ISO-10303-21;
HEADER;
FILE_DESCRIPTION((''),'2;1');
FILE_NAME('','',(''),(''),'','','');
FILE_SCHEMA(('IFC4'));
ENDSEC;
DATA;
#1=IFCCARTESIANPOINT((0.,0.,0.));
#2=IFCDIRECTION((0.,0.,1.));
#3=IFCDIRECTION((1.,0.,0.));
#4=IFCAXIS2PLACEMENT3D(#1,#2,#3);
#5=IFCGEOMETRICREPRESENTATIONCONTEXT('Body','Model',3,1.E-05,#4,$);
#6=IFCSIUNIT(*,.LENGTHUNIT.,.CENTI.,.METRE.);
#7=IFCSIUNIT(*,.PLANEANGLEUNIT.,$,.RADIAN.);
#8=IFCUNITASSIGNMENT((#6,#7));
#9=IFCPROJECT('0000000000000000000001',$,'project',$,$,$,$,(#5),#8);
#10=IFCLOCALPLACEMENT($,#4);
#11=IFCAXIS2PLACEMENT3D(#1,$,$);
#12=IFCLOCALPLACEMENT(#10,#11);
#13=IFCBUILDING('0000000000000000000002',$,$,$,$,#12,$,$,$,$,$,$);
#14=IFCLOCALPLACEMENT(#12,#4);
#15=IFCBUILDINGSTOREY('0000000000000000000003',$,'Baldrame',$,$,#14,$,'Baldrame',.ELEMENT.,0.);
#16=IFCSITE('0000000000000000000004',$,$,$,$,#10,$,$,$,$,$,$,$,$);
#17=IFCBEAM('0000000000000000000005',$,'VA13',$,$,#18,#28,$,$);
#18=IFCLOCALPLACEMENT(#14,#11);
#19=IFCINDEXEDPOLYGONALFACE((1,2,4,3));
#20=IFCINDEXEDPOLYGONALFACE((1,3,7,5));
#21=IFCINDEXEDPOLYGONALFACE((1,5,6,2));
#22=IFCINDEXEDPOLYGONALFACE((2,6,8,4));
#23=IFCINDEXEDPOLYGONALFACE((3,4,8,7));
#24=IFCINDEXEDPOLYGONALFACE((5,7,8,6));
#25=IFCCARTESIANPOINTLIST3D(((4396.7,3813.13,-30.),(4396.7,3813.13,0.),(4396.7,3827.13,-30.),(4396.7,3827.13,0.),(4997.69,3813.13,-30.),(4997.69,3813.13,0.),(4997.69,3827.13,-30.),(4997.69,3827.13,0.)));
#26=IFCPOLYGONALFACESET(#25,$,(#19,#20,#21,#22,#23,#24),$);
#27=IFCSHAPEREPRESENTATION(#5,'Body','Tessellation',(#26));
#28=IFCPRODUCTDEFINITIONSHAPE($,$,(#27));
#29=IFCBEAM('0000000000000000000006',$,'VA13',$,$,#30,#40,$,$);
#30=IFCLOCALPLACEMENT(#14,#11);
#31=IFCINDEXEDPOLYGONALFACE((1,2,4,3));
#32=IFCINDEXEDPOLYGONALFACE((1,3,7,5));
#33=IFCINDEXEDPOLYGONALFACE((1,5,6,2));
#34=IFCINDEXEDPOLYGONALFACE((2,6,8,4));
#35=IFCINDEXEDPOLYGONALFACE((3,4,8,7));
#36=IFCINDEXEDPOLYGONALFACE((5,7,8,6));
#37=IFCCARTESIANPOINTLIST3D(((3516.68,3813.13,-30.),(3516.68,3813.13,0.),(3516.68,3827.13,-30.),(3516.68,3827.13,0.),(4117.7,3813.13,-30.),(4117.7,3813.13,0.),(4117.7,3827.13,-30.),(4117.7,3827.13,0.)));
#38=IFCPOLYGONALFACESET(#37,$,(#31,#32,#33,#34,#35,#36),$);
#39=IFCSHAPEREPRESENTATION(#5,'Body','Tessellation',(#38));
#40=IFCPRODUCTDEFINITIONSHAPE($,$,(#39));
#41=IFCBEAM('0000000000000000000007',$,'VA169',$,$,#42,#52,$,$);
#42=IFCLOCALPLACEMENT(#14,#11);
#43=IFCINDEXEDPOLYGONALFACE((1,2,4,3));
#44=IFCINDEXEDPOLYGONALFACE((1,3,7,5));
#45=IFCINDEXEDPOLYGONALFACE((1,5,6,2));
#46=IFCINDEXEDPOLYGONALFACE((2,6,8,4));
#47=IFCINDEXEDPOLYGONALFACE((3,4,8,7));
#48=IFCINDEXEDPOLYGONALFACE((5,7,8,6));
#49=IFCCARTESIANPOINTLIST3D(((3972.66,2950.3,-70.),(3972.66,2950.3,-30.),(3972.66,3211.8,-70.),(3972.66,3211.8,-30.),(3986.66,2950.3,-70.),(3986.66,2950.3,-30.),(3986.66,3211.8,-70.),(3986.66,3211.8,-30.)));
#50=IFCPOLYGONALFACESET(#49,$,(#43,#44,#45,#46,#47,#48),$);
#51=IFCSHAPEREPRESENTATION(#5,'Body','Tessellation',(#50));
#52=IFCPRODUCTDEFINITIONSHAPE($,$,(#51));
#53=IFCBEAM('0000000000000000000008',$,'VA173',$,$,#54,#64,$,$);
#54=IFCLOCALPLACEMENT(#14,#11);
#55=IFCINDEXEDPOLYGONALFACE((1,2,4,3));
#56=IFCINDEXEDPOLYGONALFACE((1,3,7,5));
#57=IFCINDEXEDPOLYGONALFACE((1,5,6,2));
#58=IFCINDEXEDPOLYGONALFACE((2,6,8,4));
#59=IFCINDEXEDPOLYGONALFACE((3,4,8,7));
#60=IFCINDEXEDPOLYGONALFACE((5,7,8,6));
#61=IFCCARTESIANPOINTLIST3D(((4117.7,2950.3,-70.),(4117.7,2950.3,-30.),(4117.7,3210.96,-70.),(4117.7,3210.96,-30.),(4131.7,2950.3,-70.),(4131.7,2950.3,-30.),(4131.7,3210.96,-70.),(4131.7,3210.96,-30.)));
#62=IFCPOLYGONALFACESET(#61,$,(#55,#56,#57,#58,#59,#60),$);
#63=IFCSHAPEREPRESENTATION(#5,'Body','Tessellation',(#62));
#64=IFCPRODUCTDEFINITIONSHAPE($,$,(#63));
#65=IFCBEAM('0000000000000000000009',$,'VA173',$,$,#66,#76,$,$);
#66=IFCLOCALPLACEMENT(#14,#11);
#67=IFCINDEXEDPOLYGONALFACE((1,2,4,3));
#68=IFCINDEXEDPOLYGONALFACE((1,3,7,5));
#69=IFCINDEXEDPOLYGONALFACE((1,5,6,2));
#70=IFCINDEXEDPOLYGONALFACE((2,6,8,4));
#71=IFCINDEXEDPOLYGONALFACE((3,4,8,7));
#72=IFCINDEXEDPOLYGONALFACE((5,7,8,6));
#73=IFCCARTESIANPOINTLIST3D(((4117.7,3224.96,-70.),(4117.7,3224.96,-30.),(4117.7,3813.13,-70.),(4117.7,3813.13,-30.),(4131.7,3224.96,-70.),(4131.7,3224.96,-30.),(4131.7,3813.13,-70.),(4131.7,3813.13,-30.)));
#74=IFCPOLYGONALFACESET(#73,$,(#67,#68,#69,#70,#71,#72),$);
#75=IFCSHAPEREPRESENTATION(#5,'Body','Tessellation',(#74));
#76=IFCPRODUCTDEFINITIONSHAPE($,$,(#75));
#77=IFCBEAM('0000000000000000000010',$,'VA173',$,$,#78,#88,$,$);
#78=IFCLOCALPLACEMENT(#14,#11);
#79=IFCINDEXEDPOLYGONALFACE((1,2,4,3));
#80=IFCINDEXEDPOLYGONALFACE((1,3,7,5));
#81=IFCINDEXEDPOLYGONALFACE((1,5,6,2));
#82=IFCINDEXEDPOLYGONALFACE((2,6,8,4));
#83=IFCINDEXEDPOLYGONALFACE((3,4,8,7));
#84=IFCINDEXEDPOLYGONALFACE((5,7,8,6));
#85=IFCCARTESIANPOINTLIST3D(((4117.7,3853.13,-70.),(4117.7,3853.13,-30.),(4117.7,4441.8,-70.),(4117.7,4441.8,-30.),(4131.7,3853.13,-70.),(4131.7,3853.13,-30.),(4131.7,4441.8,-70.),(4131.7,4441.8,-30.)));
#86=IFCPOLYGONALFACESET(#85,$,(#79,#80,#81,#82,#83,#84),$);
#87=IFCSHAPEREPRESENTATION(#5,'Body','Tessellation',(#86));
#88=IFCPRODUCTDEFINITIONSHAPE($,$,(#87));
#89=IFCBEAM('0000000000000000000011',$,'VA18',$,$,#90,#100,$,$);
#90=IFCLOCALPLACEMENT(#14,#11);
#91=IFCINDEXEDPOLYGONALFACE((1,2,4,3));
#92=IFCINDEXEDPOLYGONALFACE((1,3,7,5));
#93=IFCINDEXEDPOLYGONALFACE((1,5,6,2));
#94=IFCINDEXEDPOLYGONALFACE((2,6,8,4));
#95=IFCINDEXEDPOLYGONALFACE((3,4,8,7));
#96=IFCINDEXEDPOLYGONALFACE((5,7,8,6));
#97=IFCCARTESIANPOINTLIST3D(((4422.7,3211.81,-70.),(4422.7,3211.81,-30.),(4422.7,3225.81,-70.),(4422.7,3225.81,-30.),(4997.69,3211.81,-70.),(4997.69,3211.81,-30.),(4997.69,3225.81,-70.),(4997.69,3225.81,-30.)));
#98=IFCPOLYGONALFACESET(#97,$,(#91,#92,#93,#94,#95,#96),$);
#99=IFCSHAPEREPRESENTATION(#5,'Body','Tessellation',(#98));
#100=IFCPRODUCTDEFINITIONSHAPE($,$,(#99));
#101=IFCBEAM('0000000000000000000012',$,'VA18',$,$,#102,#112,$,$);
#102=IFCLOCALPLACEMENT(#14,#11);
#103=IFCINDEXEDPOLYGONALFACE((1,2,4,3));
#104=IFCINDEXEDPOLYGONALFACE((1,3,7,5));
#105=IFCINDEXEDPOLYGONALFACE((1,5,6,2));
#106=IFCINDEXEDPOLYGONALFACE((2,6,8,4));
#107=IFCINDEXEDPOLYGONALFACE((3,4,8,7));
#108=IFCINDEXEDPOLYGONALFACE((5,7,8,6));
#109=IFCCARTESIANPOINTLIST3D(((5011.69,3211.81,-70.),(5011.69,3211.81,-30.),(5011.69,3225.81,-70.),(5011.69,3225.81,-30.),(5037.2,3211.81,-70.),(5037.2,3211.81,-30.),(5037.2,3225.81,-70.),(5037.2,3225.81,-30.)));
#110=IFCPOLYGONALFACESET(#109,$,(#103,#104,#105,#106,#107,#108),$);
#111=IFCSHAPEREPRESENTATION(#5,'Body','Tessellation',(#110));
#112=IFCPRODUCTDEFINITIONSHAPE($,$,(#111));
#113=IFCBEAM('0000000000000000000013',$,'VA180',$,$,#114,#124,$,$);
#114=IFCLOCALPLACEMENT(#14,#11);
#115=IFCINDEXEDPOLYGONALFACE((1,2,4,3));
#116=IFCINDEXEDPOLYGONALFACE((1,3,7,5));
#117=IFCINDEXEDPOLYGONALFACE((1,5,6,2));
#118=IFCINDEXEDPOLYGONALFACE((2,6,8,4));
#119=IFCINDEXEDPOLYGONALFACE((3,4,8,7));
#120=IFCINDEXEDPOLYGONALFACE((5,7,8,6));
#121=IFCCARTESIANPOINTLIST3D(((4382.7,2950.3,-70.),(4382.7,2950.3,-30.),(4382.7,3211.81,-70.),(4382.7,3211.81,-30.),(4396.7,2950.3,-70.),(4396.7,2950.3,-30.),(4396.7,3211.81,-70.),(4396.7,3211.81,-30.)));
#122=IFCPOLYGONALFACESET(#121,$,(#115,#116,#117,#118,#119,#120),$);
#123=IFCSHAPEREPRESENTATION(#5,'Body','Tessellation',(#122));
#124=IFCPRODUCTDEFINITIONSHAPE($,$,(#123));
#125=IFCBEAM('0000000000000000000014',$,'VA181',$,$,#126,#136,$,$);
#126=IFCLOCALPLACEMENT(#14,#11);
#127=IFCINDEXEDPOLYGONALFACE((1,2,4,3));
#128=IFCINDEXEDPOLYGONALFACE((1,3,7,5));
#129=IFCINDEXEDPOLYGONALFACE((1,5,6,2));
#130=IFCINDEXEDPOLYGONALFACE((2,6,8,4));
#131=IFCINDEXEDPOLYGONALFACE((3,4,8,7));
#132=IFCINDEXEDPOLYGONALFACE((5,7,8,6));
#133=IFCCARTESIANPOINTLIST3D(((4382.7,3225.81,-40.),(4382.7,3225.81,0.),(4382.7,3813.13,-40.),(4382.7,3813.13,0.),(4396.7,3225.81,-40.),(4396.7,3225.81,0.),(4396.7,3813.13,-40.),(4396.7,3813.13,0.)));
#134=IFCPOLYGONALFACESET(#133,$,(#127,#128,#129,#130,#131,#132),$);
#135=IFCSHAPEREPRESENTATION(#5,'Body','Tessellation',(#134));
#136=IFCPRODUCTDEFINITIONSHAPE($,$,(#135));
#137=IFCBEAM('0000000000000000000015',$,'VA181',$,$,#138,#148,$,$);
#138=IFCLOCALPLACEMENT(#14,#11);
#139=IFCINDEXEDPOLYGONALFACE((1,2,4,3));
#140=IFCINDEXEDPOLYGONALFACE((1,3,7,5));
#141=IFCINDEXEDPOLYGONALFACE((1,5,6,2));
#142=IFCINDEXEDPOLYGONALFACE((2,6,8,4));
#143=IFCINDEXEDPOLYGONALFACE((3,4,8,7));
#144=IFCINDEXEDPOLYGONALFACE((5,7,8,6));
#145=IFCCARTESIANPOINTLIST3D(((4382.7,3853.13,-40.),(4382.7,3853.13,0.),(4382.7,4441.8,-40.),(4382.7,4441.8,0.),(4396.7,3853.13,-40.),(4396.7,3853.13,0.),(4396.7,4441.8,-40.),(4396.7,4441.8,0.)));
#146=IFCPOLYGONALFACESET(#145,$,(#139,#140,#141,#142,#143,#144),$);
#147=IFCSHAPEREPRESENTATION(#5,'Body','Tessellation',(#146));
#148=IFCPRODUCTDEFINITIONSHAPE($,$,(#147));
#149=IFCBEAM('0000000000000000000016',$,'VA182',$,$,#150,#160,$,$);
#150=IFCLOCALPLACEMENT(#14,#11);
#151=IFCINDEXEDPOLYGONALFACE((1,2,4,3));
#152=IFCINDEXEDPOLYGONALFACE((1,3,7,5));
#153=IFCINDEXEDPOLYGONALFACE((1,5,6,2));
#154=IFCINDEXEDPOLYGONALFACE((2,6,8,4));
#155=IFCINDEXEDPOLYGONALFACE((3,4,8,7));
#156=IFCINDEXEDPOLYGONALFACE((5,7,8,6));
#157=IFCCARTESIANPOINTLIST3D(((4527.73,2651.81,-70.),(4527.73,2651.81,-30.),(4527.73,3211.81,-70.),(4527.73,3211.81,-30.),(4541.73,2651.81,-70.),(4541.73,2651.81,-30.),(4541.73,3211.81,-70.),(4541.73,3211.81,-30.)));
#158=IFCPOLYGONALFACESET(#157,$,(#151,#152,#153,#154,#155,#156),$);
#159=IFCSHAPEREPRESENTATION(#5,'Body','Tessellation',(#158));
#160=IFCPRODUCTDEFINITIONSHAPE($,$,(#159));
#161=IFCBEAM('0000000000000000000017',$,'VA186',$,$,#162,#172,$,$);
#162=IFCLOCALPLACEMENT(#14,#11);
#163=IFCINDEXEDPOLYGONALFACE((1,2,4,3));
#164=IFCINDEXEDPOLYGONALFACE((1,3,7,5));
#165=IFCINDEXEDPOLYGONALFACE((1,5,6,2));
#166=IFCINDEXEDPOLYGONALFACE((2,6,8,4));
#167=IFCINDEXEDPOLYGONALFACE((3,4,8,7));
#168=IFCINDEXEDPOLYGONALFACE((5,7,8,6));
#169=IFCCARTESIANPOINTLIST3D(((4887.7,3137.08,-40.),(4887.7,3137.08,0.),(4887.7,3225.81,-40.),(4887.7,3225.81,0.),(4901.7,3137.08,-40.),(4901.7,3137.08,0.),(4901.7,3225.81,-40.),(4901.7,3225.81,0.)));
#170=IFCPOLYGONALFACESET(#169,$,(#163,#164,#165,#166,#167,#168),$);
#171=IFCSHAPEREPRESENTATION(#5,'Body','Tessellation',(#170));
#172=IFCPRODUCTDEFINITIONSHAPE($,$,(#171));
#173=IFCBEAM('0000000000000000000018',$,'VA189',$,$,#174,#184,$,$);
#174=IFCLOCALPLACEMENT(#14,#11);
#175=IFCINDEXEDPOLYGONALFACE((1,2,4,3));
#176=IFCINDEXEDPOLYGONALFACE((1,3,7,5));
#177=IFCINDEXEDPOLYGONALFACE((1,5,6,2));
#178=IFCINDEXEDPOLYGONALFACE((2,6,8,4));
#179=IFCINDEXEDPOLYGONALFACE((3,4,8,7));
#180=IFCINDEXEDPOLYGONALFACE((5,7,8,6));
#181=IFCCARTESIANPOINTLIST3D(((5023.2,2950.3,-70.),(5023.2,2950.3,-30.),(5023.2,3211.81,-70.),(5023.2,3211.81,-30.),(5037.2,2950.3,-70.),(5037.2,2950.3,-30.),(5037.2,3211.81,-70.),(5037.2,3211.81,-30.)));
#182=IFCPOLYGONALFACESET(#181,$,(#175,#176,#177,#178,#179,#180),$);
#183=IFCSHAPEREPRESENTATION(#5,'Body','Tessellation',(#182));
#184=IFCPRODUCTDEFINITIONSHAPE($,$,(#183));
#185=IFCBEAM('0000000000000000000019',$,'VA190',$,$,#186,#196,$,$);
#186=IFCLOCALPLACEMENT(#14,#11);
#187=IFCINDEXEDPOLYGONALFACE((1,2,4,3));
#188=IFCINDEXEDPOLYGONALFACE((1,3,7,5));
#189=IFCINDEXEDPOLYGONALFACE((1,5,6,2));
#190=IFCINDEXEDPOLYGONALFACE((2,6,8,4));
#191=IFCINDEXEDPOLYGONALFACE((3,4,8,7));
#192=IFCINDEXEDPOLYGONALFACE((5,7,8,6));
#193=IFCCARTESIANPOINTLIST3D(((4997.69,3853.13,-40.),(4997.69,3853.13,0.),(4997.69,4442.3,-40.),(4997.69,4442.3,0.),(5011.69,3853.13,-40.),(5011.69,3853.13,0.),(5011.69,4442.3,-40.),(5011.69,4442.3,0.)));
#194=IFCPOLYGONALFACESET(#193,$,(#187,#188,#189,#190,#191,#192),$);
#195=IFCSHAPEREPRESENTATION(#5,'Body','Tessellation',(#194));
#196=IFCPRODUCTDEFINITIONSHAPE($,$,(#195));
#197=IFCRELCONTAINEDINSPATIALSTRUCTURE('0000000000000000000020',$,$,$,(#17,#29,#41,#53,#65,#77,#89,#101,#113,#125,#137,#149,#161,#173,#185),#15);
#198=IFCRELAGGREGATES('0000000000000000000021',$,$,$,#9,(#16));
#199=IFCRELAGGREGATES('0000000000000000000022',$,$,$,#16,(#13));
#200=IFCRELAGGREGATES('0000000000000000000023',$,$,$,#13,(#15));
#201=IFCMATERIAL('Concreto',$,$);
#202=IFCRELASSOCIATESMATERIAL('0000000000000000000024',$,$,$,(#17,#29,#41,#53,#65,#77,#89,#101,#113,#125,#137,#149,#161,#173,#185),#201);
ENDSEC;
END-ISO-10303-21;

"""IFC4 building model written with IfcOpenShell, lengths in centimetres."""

from ifc_helpers import new_model, si_unit, frame, origin, origin_with_axes, origin_2d_with_axis, place, context, project, spatial, rectangle, extrude, material, element, save


model = new_model("IFC4")

# Units and contexts
model_context = context("Model", 3, precision=1e-05, world=origin_with_axes(), identifier="Body")
ifc_project = project(units=[si_unit("LENGTHUNIT", "METRE", prefix="CENTI"), si_unit("PLANEANGLEUNIT", "RADIAN")], contexts=[model_context])

# Site, building, storey
site_placement = place(None, origin_with_axes())
site = spatial("IfcSite", under=ifc_project, at=site_placement)
building_placement = place(site_placement, origin())
building = spatial("IfcBuilding", under=site, at=building_placement)
storey_placement = place(building_placement, origin_with_axes())
storey = spatial("IfcBuildingStorey", under=building, at=storey_placement, Name="Baldrame", LongName="Baldrame", CompositionType="ELEMENT", Elevation=0.0)

# Shared definitions
ifc_material = material(Name="Concreto")

# Beams
beam_1_placement = place(storey_placement, frame((4697.19, 3820.13, 0.0), z_axis=(0.0, 0.0, 1.0), x_axis=(1.0, 0.0, 0.0)))
element("IfcBeam", 1, at=beam_1_placement, inside=storey, material=ifc_material, Name="VA13", context=model_context, shape_type="SolidModel", body=[
    extrude(rectangle(XDim=14.0, YDim=30.0, at=origin_2d_with_axis()), frame((-300.5, 0.0, -15.0), z_axis=(1.0, 0.0, 0.0), x_axis=(0.0, 1.0, 0.0)), (0.0, 0.0, 1.0), 600.99),
])
beam_2_placement = place(storey_placement, frame((3817.19, 3820.13, 0.0), z_axis=(0.0, 0.0, 1.0), x_axis=(1.0, 0.0, 0.0)))
element("IfcBeam", 2, at=beam_2_placement, inside=storey, material=ifc_material, Name="VA13", context=model_context, shape_type="SolidModel", body=[
    extrude(rectangle(XDim=14.0, YDim=30.0, at=origin_2d_with_axis()), frame((-300.51, 0.0, -15.0), z_axis=(1.0, 0.0, 0.0), x_axis=(0.0, 1.0, 0.0)), (0.0, 0.0, 1.0), 601.02),
])
beam_3_placement = place(storey_placement, frame((3979.66, 3081.05, -30.0), z_axis=(0.0, 0.0, 1.0), x_axis=(1.0, 0.0, 0.0)))
element("IfcBeam", 3, at=beam_3_placement, inside=storey, material=ifc_material, Name="VA169", context=model_context, shape_type="SolidModel", body=[
    extrude(rectangle(XDim=14.0, YDim=40.0, at=origin_2d_with_axis()), frame((0.0, -130.75, -20.0), z_axis=(0.0, 1.0, 0.0), x_axis=(1.0, 0.0, 0.0)), (0.0, 0.0, 1.0), 261.5),
])
beam_4_placement = place(storey_placement, frame((4124.7, 3080.63, -30.0), z_axis=(0.0, 0.0, 1.0), x_axis=(1.0, 0.0, 0.0)))
element("IfcBeam", 4, at=beam_4_placement, inside=storey, material=ifc_material, Name="VA173", context=model_context, shape_type="SolidModel", body=[
    extrude(rectangle(XDim=14.0, YDim=40.0, at=origin_2d_with_axis()), frame((0.0, -130.33, -20.0), z_axis=(0.0, 1.0, 0.0), x_axis=(1.0, 0.0, 0.0)), (0.0, 0.0, 1.0), 260.66),
])
beam_5_placement = place(storey_placement, frame((4124.7, 3519.05, -30.0), z_axis=(0.0, 0.0, 1.0), x_axis=(1.0, 0.0, 0.0)))
element("IfcBeam", 5, at=beam_5_placement, inside=storey, material=ifc_material, Name="VA173", context=model_context, shape_type="SolidModel", body=[
    extrude(rectangle(XDim=14.0, YDim=40.0, at=origin_2d_with_axis()), frame((0.0, -294.08, -20.0), z_axis=(0.0, 1.0, 0.0), x_axis=(1.0, 0.0, 0.0)), (0.0, 0.0, 1.0), 588.17),
])
beam_6_placement = place(storey_placement, frame((4124.7, 4147.47, -30.0), z_axis=(0.0, 0.0, 1.0), x_axis=(1.0, 0.0, 0.0)))
element("IfcBeam", 6, at=beam_6_placement, inside=storey, material=ifc_material, Name="VA173", context=model_context, shape_type="SolidModel", body=[
    extrude(rectangle(XDim=14.0, YDim=40.0, at=origin_2d_with_axis()), frame((0.0, -294.33, -20.0), z_axis=(0.0, 1.0, 0.0), x_axis=(1.0, 0.0, 0.0)), (0.0, 0.0, 1.0), 588.67),
])
beam_7_placement = place(storey_placement, frame((4710.19, 3218.81, -30.0), z_axis=(0.0, 0.0, 1.0), x_axis=(1.0, 0.0, 0.0)))
element("IfcBeam", 7, at=beam_7_placement, inside=storey, material=ifc_material, Name="VA18", context=model_context, shape_type="SolidModel", body=[
    extrude(rectangle(XDim=14.0, YDim=40.0, at=origin_2d_with_axis()), frame((-287.5, 0.0, -20.0), z_axis=(1.0, 0.0, 0.0), x_axis=(0.0, 1.0, 0.0)), (0.0, 0.0, 1.0), 574.99),
])
beam_8_placement = place(storey_placement, frame((5024.44, 3218.81, -30.0), z_axis=(0.0, 0.0, 1.0), x_axis=(1.0, 0.0, 0.0)))
element("IfcBeam", 8, at=beam_8_placement, inside=storey, material=ifc_material, Name="VA18", context=model_context, shape_type="SolidModel", body=[
    extrude(rectangle(XDim=14.0, YDim=40.0, at=origin_2d_with_axis()), frame((-12.76, 0.0, -20.0), z_axis=(1.0, 0.0, 0.0), x_axis=(0.0, 1.0, 0.0)), (0.0, 0.0, 1.0), 25.51),
])
beam_9_placement = place(storey_placement, frame((4389.7, 3081.05, -30.0), z_axis=(0.0, 0.0, 1.0), x_axis=(1.0, 0.0, 0.0)))
element("IfcBeam", 9, at=beam_9_placement, inside=storey, material=ifc_material, Name="VA180", context=model_context, shape_type="SolidModel", body=[
    extrude(rectangle(XDim=14.0, YDim=40.0, at=origin_2d_with_axis()), frame((0.0, -130.75, -20.0), z_axis=(0.0, 1.0, 0.0), x_axis=(1.0, 0.0, 0.0)), (0.0, 0.0, 1.0), 261.51),
])
beam_10_placement = place(storey_placement, frame((4389.7, 3519.47, 0.0), z_axis=(0.0, 0.0, 1.0), x_axis=(1.0, 0.0, 0.0)))
element("IfcBeam", 10, at=beam_10_placement, inside=storey, material=ifc_material, Name="VA181", context=model_context, shape_type="SolidModel", body=[
    extrude(rectangle(XDim=14.0, YDim=40.0, at=origin_2d_with_axis()), frame((0.0, -293.66, -20.0), z_axis=(0.0, 1.0, 0.0), x_axis=(1.0, 0.0, 0.0)), (0.0, 0.0, 1.0), 587.32),
])
beam_11_placement = place(storey_placement, frame((4389.7, 4147.47, 0.0), z_axis=(0.0, 0.0, 1.0), x_axis=(1.0, 0.0, 0.0)))
element("IfcBeam", 11, at=beam_11_placement, inside=storey, material=ifc_material, Name="VA181", context=model_context, shape_type="SolidModel", body=[
    extrude(rectangle(XDim=14.0, YDim=40.0, at=origin_2d_with_axis()), frame((0.0, -294.33, -20.0), z_axis=(0.0, 1.0, 0.0), x_axis=(1.0, 0.0, 0.0)), (0.0, 0.0, 1.0), 588.67),
])
beam_12_placement = place(storey_placement, frame((4534.73, 2931.81, -30.0), z_axis=(0.0, 0.0, 1.0), x_axis=(1.0, 0.0, 0.0)))
element("IfcBeam", 12, at=beam_12_placement, inside=storey, material=ifc_material, Name="VA182", context=model_context, shape_type="SolidModel", body=[
    extrude(rectangle(XDim=14.0, YDim=40.0, at=origin_2d_with_axis()), frame((0.0, -280.0, -20.0), z_axis=(0.0, 1.0, 0.0), x_axis=(1.0, 0.0, 0.0)), (0.0, 0.0, 1.0), 560.0),
])
beam_13_placement = place(storey_placement, frame((4894.7, 3181.44, 0.0), z_axis=(0.0, 0.0, 1.0), x_axis=(1.0, 0.0, 0.0)))
element("IfcBeam", 13, at=beam_13_placement, inside=storey, material=ifc_material, Name="VA186", context=model_context, shape_type="SolidModel", body=[
    extrude(rectangle(XDim=14.0, YDim=40.0, at=origin_2d_with_axis()), frame((0.0, -44.37, -20.0), z_axis=(0.0, 1.0, 0.0), x_axis=(1.0, 0.0, 0.0)), (0.0, 0.0, 1.0), 88.73),
])
beam_14_placement = place(storey_placement, frame((5030.2, 3081.05, -30.0), z_axis=(0.0, 0.0, 1.0), x_axis=(1.0, 0.0, 0.0)))
element("IfcBeam", 14, at=beam_14_placement, inside=storey, material=ifc_material, Name="VA189", context=model_context, shape_type="SolidModel", body=[
    extrude(rectangle(XDim=14.0, YDim=40.0, at=origin_2d_with_axis()), frame((0.0, -130.75, -20.0), z_axis=(0.0, 1.0, 0.0), x_axis=(1.0, 0.0, 0.0)), (0.0, 0.0, 1.0), 261.51),
])
beam_15_placement = place(storey_placement, frame((5004.69, 4147.72, 0.0), z_axis=(0.0, 0.0, 1.0), x_axis=(1.0, 0.0, 0.0)))
element("IfcBeam", 15, at=beam_15_placement, inside=storey, material=ifc_material, Name="VA190", context=model_context, shape_type="SolidModel", body=[
    extrude(rectangle(XDim=14.0, YDim=40.0, at=origin_2d_with_axis()), frame((0.0, -294.58, -20.0), z_axis=(0.0, 1.0, 0.0), x_axis=(1.0, 0.0, 0.0)), (0.0, 0.0, 1.0), 589.17),
])

save(model, "model.ifc")
